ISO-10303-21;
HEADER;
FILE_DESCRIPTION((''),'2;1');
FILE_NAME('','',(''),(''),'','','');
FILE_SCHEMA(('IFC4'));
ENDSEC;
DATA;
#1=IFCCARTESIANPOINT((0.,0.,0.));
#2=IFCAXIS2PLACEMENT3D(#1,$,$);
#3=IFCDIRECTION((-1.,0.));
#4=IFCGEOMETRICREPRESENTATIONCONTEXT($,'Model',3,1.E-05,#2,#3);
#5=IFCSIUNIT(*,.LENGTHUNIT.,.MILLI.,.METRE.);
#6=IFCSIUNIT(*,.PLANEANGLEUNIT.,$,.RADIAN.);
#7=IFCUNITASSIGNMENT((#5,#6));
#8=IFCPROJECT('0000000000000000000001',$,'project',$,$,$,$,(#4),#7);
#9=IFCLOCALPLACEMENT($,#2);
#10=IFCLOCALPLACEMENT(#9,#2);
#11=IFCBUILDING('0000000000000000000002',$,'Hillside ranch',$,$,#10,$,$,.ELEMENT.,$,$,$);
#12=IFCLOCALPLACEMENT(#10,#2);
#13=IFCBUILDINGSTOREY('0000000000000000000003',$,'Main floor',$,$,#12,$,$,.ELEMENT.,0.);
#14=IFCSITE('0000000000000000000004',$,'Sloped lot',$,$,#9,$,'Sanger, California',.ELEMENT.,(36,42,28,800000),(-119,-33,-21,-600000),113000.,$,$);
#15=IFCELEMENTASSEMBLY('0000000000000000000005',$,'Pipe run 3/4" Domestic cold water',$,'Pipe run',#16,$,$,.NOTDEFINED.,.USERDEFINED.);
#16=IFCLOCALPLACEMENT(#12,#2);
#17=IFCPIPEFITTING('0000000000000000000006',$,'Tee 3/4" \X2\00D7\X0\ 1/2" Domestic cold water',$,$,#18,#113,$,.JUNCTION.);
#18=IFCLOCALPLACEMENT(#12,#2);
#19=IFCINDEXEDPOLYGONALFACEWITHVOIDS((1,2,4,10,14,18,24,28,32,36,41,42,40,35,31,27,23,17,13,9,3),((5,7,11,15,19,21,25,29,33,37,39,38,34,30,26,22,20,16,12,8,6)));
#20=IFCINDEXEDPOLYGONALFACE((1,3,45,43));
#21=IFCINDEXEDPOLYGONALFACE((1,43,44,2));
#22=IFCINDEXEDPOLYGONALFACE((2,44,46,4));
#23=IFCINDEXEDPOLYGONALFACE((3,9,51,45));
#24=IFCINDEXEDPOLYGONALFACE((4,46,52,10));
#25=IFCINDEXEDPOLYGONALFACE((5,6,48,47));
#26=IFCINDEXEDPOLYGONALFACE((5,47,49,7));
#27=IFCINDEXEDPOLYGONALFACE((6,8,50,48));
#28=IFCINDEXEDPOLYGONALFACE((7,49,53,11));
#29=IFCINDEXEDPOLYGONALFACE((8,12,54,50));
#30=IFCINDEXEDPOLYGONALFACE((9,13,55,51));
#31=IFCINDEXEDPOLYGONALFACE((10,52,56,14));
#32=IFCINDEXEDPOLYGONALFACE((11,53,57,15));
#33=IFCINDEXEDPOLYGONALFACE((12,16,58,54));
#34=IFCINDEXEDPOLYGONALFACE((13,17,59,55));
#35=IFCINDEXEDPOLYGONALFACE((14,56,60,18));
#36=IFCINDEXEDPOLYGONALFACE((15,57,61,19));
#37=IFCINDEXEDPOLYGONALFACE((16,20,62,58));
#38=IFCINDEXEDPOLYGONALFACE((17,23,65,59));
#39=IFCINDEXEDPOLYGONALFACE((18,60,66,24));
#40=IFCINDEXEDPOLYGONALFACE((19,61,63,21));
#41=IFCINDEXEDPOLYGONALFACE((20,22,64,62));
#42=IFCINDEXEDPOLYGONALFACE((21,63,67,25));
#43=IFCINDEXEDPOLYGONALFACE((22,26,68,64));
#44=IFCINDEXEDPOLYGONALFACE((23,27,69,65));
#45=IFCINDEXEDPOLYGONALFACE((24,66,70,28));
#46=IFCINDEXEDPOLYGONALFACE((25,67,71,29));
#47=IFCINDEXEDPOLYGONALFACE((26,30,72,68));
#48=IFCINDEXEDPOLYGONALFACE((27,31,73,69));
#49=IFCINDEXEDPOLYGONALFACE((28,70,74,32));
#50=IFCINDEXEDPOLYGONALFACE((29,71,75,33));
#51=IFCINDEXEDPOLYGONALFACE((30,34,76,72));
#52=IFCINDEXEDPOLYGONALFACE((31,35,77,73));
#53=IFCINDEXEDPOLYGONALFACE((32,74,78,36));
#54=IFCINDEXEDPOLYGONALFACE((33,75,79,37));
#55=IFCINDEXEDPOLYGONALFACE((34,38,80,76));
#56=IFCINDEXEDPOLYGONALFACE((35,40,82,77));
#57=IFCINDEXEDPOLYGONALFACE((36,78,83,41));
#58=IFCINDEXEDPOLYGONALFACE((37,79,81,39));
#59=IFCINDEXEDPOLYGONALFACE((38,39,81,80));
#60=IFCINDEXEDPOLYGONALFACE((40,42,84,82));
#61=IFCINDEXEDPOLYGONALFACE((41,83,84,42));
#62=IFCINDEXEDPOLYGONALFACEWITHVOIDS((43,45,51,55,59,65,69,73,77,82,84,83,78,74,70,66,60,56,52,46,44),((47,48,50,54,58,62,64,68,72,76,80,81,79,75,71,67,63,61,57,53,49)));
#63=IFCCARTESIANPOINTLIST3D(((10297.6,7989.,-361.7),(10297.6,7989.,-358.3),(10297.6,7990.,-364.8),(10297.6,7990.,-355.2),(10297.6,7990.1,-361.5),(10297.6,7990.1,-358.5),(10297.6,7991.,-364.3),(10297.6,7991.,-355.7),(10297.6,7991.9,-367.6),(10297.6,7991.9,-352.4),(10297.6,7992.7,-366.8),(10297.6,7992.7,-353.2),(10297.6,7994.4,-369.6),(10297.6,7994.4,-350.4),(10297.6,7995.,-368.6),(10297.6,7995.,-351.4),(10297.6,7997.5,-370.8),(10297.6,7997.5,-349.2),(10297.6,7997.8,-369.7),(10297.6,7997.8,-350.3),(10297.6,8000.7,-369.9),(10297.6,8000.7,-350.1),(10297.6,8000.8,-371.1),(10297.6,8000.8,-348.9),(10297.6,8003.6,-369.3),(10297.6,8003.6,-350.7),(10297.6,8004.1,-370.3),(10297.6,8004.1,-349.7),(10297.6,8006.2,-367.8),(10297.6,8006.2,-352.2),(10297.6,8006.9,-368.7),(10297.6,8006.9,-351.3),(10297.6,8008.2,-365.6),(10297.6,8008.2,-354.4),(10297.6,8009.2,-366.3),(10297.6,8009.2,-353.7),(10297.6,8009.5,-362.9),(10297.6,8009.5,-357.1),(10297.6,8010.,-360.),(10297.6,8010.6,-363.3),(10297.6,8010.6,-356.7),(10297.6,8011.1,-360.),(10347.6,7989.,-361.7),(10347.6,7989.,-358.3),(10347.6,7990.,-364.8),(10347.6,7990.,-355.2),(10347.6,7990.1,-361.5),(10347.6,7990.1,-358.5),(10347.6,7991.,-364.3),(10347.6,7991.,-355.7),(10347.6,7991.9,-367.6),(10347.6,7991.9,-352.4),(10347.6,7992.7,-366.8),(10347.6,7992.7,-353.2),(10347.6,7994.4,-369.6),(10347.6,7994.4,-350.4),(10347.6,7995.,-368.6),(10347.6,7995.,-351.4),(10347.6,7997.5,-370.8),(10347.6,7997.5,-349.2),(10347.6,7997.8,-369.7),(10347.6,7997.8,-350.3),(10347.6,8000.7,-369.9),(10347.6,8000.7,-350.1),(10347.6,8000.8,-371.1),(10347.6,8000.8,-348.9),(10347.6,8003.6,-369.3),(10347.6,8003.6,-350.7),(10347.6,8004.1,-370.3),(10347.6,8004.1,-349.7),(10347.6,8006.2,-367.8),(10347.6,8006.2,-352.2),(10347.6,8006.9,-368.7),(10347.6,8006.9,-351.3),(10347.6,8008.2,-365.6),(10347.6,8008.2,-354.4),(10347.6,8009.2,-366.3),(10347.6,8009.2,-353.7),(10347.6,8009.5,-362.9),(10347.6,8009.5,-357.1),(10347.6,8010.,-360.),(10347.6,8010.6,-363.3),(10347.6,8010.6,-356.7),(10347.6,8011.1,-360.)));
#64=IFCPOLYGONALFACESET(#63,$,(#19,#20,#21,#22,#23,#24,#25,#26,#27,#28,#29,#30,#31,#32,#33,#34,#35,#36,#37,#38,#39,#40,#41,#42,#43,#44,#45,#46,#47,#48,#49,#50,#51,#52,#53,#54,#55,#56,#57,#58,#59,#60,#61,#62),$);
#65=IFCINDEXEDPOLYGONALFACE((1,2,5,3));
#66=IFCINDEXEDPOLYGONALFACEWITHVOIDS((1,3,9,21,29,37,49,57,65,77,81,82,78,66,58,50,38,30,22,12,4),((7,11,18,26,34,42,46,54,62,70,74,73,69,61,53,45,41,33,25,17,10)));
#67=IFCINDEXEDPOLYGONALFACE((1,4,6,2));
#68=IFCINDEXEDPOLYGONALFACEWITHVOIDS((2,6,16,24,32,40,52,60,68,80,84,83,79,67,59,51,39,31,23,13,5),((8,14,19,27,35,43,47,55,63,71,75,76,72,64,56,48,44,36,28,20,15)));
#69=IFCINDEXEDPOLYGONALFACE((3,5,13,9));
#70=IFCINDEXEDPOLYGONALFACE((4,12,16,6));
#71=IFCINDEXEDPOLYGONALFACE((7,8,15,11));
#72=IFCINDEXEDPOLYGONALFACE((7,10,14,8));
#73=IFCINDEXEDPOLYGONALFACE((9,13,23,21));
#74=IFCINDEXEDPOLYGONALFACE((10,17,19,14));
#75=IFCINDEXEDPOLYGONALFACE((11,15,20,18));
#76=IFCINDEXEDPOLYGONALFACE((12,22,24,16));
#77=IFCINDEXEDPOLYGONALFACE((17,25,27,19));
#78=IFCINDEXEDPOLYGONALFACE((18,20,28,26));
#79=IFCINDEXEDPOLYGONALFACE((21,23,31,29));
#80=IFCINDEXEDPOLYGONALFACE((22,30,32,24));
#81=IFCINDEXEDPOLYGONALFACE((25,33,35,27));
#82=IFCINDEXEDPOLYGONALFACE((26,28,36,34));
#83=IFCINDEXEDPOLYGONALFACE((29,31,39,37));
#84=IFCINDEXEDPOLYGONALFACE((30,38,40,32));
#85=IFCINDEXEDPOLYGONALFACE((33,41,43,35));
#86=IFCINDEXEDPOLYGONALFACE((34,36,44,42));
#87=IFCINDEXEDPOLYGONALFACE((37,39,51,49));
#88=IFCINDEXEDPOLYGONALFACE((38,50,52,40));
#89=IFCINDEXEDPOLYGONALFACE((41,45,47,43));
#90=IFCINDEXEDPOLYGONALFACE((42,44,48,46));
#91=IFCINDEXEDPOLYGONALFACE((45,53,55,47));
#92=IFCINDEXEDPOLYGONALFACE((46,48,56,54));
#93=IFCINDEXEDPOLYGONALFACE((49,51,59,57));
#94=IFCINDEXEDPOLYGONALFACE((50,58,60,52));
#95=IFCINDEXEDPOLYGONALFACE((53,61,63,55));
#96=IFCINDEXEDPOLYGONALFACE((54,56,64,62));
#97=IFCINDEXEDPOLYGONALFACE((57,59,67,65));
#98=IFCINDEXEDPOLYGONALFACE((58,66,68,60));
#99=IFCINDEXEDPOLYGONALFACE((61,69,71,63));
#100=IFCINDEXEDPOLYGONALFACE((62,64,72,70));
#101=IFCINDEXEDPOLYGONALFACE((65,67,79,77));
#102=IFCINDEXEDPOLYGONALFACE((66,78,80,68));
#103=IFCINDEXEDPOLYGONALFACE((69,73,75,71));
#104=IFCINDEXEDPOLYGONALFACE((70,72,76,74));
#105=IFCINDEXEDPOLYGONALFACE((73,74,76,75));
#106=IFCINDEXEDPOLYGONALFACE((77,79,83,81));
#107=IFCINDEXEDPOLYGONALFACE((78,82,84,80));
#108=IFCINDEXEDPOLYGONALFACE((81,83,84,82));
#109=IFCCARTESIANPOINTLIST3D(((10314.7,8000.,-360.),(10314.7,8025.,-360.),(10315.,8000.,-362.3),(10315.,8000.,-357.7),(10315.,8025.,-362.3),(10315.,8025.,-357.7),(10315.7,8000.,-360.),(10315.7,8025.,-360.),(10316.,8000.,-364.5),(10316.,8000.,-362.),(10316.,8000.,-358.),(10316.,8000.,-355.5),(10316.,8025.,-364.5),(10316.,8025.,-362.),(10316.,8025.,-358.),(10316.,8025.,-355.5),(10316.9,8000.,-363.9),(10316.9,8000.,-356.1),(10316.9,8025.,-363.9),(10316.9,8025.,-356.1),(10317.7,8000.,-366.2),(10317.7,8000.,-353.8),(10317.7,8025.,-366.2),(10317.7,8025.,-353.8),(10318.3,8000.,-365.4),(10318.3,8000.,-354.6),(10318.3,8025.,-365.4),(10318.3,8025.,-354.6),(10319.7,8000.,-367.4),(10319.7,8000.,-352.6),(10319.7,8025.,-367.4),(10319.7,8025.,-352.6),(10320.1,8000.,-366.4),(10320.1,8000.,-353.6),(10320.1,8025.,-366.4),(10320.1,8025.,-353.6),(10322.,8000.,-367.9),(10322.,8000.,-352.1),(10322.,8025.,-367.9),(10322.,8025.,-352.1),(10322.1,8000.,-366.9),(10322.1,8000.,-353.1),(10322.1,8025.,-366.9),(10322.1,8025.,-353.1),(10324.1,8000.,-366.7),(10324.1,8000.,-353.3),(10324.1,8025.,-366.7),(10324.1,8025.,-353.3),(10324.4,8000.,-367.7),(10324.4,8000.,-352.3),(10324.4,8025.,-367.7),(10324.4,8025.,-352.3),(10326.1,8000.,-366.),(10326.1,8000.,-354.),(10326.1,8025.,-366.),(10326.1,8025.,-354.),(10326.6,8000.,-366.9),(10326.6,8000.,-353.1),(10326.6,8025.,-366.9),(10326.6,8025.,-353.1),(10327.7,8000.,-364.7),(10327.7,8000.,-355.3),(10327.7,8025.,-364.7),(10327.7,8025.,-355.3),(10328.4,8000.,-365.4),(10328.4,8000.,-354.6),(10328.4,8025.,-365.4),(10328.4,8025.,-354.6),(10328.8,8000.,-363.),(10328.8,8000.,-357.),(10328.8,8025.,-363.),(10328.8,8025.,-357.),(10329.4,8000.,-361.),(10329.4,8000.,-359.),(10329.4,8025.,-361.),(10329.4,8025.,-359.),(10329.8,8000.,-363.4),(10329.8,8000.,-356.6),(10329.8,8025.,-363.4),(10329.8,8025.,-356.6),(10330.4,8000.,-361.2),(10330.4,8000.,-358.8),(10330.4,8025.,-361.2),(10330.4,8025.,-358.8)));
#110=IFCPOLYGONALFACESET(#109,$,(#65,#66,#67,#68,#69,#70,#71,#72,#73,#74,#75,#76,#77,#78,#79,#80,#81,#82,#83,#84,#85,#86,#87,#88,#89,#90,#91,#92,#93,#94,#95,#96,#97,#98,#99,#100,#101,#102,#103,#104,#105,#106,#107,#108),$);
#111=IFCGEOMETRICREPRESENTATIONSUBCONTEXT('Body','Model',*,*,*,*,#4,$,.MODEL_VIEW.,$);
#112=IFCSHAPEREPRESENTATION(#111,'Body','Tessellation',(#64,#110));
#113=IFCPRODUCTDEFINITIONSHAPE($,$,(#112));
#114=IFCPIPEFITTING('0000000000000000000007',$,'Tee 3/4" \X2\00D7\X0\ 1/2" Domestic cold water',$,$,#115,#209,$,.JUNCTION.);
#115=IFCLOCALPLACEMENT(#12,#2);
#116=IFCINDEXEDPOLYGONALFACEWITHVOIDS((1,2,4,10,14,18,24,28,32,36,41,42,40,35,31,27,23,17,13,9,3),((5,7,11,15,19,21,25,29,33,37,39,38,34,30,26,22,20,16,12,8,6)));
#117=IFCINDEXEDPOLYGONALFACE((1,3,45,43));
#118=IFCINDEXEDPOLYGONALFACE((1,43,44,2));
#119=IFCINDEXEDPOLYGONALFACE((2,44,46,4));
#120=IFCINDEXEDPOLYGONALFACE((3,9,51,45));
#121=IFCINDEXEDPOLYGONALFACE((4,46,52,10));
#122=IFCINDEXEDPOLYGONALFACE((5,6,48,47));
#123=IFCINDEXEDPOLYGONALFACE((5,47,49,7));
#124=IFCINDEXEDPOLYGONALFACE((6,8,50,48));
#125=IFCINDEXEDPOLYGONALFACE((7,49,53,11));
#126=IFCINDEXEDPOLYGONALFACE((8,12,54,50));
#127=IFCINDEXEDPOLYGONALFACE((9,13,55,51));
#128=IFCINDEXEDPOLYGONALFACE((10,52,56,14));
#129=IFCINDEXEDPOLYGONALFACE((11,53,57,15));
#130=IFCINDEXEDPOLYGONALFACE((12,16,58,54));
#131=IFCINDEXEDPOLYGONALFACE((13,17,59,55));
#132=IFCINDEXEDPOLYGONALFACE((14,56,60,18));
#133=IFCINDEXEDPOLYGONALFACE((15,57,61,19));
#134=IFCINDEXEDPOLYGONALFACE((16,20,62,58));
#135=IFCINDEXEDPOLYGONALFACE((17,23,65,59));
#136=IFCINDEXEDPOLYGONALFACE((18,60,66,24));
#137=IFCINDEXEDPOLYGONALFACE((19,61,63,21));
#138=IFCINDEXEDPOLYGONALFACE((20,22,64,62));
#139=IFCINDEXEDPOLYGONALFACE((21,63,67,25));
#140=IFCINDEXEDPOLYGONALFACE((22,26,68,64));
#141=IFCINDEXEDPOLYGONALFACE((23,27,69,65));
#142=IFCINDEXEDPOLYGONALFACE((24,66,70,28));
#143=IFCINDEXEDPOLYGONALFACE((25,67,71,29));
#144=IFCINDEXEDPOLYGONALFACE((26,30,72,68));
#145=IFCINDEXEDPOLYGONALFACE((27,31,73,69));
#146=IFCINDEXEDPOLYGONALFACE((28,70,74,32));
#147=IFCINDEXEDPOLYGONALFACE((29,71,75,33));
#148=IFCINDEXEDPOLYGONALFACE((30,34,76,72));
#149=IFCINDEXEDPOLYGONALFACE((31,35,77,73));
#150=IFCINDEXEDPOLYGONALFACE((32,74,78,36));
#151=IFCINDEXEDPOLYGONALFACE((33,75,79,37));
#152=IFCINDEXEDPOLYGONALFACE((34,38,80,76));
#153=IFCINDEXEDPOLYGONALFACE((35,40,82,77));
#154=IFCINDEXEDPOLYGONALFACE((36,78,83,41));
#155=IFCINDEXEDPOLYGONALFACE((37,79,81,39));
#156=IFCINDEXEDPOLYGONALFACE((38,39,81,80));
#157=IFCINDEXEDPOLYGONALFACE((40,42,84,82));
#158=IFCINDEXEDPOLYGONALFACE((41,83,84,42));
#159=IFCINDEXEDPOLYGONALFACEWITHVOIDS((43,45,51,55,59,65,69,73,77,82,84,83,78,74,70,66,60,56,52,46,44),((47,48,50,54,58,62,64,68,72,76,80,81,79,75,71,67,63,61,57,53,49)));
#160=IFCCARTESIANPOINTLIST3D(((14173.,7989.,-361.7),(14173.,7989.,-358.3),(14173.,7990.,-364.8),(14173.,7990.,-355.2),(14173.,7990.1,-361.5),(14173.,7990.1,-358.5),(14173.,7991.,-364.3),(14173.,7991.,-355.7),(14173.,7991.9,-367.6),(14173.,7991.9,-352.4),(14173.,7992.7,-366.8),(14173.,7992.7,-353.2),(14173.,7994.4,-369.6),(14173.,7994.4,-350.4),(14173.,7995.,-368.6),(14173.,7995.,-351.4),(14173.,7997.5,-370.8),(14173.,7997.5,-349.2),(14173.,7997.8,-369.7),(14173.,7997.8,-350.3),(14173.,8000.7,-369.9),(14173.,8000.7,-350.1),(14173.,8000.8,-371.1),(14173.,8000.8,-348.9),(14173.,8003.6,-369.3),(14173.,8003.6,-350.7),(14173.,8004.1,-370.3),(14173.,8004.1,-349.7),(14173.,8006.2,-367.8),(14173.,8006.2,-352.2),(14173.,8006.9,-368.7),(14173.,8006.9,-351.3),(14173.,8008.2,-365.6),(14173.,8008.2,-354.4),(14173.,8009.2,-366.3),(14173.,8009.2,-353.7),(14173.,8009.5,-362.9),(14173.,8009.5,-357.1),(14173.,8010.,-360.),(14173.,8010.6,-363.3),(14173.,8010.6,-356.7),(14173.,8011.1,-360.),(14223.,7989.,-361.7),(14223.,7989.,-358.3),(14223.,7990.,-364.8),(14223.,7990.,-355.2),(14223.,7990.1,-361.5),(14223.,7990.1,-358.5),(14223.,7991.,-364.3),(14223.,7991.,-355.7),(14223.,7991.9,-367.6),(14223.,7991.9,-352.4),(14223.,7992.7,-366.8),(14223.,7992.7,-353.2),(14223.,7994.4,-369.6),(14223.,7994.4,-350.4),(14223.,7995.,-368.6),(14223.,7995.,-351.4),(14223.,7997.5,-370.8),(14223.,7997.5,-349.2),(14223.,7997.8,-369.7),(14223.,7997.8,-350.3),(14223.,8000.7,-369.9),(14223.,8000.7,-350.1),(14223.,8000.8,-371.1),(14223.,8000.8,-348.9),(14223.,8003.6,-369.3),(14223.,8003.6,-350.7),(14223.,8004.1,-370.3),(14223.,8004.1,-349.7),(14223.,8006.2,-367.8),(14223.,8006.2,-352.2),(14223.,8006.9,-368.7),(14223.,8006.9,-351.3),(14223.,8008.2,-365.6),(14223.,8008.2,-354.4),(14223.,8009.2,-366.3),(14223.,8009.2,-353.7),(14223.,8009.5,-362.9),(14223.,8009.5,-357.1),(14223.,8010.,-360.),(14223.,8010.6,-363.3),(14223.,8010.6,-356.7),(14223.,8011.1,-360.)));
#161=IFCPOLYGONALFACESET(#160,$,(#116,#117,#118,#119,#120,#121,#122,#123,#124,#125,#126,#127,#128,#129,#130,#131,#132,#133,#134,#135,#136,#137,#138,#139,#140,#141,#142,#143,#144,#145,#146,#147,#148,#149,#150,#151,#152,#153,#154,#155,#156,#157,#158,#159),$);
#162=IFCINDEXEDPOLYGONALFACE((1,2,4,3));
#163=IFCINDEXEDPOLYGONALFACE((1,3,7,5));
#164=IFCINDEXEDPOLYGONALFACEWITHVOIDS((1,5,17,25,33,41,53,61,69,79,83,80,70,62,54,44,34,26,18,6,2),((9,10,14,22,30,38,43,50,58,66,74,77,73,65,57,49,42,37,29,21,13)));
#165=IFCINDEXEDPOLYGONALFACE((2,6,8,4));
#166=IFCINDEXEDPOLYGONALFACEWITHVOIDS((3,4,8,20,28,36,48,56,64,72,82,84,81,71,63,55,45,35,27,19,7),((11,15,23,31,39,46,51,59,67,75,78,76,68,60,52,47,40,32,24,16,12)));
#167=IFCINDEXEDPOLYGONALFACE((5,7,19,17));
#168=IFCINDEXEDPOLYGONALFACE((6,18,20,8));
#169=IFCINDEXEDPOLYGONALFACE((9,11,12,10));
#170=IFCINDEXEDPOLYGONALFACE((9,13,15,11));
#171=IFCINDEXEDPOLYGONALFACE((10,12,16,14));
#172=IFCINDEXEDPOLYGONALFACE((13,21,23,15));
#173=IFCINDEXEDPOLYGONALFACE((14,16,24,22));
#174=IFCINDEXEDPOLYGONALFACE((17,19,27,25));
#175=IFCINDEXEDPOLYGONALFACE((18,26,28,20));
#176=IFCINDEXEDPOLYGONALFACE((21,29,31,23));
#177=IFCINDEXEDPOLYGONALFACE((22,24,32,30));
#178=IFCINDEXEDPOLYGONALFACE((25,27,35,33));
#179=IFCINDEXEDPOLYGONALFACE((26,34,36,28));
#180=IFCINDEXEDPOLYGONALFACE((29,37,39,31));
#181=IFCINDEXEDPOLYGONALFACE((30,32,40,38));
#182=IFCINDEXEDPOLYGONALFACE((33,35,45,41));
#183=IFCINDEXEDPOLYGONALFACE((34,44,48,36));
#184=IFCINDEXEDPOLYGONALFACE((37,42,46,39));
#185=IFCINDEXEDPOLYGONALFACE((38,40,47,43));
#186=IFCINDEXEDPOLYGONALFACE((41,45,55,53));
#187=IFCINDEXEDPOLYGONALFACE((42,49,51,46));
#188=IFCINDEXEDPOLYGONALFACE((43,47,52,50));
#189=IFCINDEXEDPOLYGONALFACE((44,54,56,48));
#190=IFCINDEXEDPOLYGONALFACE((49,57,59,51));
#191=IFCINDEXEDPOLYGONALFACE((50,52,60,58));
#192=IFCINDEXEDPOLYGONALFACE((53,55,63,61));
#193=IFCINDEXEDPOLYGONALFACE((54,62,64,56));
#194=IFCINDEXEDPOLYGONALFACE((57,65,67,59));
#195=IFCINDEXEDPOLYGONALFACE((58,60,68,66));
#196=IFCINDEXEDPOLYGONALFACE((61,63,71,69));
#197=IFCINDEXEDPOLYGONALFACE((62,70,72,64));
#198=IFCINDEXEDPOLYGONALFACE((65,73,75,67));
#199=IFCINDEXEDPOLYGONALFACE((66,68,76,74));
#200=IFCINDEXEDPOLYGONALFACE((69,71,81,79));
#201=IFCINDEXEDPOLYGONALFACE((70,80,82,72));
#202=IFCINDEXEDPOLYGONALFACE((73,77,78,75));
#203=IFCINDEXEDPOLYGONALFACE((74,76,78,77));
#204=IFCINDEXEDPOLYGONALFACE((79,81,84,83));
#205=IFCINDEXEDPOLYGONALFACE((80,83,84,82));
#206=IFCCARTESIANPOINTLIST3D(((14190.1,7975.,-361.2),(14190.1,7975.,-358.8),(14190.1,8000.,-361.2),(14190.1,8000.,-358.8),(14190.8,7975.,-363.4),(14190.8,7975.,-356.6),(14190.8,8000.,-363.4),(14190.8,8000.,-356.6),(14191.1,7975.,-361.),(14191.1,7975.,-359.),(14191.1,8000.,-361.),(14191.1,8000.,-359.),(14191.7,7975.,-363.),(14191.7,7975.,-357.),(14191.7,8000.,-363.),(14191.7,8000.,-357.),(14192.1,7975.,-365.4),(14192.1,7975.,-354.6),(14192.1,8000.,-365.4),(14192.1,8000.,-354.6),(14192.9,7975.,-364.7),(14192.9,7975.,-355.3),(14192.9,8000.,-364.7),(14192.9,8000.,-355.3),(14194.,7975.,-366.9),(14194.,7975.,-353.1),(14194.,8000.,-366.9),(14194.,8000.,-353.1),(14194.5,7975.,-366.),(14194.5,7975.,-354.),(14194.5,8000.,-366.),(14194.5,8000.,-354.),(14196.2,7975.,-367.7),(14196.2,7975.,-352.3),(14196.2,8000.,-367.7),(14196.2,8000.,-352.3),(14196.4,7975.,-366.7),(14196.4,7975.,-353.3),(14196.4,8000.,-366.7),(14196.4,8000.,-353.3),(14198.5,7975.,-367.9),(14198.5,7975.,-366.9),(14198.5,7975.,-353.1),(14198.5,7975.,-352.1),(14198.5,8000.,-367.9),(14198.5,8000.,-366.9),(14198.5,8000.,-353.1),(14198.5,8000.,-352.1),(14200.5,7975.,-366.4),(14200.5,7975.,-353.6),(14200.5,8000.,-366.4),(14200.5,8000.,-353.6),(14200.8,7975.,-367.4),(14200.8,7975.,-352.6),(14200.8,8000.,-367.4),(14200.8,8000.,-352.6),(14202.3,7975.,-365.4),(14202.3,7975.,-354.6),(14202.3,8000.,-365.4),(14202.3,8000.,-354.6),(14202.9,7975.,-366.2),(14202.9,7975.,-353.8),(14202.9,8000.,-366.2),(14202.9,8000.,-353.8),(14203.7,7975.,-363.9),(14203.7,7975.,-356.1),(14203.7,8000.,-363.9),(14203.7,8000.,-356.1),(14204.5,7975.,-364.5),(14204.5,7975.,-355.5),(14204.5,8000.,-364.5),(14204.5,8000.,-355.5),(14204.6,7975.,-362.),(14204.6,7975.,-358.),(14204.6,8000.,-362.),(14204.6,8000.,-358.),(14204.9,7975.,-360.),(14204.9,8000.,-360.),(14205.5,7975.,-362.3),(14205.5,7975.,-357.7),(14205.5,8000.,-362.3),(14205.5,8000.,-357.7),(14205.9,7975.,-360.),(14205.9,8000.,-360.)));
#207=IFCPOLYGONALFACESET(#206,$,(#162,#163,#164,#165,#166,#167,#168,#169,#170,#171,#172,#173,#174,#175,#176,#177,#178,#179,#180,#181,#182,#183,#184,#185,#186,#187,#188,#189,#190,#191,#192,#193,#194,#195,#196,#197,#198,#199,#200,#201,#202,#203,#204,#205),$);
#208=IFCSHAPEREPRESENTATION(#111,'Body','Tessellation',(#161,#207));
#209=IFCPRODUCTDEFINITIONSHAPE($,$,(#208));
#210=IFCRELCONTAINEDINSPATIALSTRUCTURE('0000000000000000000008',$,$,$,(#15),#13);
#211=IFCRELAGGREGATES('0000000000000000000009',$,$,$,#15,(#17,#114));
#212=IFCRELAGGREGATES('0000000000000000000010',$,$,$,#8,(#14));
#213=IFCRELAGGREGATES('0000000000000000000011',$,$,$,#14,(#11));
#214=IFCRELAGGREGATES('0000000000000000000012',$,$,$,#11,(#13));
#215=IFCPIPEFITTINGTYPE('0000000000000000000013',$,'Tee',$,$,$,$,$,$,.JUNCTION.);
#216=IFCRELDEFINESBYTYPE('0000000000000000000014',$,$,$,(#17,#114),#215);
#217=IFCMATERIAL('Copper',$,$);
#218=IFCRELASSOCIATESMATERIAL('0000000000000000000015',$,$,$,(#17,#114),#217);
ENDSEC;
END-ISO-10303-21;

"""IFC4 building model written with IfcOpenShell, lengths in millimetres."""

from ifc_helpers import new_model, si_unit, direction, frame, origin, origin_with_axes, origin_2d, place, context, subcontext, project, spatial, hollow_circle, extrude, material, type_object, element, aggregate, save


model = new_model("IFC4")

# Units and contexts
model_context = context("Model", 3, precision=1e-05, world=origin(), true_north=direction((-1.0, 0.0)))
body_context = subcontext(model_context, "Body", "Model", "MODEL_VIEW")
ifc_project = project(units=[si_unit("LENGTHUNIT", "METRE", prefix="MILLI"), si_unit("PLANEANGLEUNIT", "RADIAN")], contexts=[model_context])

# Site, building, storey
site_placement = place(None, origin())
site = spatial("IfcSite", under=ifc_project, at=site_placement, Name="Sloped lot", LongName="Sanger, California", CompositionType="ELEMENT", RefLatitude=(36, 42, 28, 800000), RefLongitude=(-119, -33, -21, -600000), RefElevation=113000.0)
building_placement = place(site_placement, origin())
building = spatial("IfcBuilding", under=site, at=building_placement, Name="Hillside ranch", CompositionType="ELEMENT")
storey_placement = place(building_placement, origin())
storey = spatial("IfcBuildingStorey", under=building, at=storey_placement, Name="Main floor", CompositionType="ELEMENT", Elevation=0.0)

# Element assembly, pipe fittings
assembly_1_placement = place(storey_placement, origin_with_axes())
assembly_1 = element("IfcElementAssembly", 1, at=assembly_1_placement, inside=storey, Name="Pipe run 3/4\" Domestic cold water", ObjectType="Pipe run", AssemblyPlace="NOTDEFINED", PredefinedType="USERDEFINED")
ifc_material = material(Name="Copper")
pipe_fitting_type_1 = type_object("IfcPipeFittingType", Name="Tee", PredefinedType="JUNCTION")
pipe_fitting_1_placement = place(storey_placement, origin_with_axes())
pipe_fitting_1 = element("IfcPipeFitting", 2, at=pipe_fitting_1_placement, type_object=pipe_fitting_type_1, material=ifc_material, Name="Tee 3/4\" × 1/2\" Domestic cold water", PredefinedType="JUNCTION", context=body_context, shape_type="SweptSolid", body=[
    extrude(hollow_circle(Radius=11.1, WallThickness=1.1, at=origin_2d()), frame((10297.6, 8000.0, -360.0), z_axis=(1.0, 0.0, 0.0), x_axis=(0.0, 1.0, 0.0)), (0.0, 0.0, 1.0), 50.0),
    extrude(hollow_circle(Radius=7.9, WallThickness=1.0, at=origin_2d()), frame((10322.6, 8000.0, -360.0), z_axis=(0.0, 1.0, 0.0), x_axis=(-1.0, 0.0, 0.0)), (0.0, 0.0, 1.0), 25.0),
])
pipe_fitting_2_placement = place(storey_placement, origin_with_axes())
pipe_fitting_2 = element("IfcPipeFitting", 3, at=pipe_fitting_2_placement, type_object=pipe_fitting_type_1, material=ifc_material, Name="Tee 3/4\" × 1/2\" Domestic cold water", PredefinedType="JUNCTION", context=body_context, shape_type="SweptSolid", body=[
    extrude(hollow_circle(Radius=11.1, WallThickness=1.1, at=origin_2d()), frame((14173.0, 8000.0, -360.0), z_axis=(1.0, 0.0, 0.0), x_axis=(0.0, 1.0, 0.0)), (0.0, 0.0, 1.0), 50.0),
    extrude(hollow_circle(Radius=7.9, WallThickness=1.0, at=origin_2d()), frame((14198.0, 8000.0, -360.0), z_axis=(0.0, -1.0, 0.0), x_axis=(1.0, 0.0, 0.0)), (0.0, 0.0, 1.0), 25.0),
])

aggregate(assembly_1, [pipe_fitting_1, pipe_fitting_2])

save(model, "model.ifc")
